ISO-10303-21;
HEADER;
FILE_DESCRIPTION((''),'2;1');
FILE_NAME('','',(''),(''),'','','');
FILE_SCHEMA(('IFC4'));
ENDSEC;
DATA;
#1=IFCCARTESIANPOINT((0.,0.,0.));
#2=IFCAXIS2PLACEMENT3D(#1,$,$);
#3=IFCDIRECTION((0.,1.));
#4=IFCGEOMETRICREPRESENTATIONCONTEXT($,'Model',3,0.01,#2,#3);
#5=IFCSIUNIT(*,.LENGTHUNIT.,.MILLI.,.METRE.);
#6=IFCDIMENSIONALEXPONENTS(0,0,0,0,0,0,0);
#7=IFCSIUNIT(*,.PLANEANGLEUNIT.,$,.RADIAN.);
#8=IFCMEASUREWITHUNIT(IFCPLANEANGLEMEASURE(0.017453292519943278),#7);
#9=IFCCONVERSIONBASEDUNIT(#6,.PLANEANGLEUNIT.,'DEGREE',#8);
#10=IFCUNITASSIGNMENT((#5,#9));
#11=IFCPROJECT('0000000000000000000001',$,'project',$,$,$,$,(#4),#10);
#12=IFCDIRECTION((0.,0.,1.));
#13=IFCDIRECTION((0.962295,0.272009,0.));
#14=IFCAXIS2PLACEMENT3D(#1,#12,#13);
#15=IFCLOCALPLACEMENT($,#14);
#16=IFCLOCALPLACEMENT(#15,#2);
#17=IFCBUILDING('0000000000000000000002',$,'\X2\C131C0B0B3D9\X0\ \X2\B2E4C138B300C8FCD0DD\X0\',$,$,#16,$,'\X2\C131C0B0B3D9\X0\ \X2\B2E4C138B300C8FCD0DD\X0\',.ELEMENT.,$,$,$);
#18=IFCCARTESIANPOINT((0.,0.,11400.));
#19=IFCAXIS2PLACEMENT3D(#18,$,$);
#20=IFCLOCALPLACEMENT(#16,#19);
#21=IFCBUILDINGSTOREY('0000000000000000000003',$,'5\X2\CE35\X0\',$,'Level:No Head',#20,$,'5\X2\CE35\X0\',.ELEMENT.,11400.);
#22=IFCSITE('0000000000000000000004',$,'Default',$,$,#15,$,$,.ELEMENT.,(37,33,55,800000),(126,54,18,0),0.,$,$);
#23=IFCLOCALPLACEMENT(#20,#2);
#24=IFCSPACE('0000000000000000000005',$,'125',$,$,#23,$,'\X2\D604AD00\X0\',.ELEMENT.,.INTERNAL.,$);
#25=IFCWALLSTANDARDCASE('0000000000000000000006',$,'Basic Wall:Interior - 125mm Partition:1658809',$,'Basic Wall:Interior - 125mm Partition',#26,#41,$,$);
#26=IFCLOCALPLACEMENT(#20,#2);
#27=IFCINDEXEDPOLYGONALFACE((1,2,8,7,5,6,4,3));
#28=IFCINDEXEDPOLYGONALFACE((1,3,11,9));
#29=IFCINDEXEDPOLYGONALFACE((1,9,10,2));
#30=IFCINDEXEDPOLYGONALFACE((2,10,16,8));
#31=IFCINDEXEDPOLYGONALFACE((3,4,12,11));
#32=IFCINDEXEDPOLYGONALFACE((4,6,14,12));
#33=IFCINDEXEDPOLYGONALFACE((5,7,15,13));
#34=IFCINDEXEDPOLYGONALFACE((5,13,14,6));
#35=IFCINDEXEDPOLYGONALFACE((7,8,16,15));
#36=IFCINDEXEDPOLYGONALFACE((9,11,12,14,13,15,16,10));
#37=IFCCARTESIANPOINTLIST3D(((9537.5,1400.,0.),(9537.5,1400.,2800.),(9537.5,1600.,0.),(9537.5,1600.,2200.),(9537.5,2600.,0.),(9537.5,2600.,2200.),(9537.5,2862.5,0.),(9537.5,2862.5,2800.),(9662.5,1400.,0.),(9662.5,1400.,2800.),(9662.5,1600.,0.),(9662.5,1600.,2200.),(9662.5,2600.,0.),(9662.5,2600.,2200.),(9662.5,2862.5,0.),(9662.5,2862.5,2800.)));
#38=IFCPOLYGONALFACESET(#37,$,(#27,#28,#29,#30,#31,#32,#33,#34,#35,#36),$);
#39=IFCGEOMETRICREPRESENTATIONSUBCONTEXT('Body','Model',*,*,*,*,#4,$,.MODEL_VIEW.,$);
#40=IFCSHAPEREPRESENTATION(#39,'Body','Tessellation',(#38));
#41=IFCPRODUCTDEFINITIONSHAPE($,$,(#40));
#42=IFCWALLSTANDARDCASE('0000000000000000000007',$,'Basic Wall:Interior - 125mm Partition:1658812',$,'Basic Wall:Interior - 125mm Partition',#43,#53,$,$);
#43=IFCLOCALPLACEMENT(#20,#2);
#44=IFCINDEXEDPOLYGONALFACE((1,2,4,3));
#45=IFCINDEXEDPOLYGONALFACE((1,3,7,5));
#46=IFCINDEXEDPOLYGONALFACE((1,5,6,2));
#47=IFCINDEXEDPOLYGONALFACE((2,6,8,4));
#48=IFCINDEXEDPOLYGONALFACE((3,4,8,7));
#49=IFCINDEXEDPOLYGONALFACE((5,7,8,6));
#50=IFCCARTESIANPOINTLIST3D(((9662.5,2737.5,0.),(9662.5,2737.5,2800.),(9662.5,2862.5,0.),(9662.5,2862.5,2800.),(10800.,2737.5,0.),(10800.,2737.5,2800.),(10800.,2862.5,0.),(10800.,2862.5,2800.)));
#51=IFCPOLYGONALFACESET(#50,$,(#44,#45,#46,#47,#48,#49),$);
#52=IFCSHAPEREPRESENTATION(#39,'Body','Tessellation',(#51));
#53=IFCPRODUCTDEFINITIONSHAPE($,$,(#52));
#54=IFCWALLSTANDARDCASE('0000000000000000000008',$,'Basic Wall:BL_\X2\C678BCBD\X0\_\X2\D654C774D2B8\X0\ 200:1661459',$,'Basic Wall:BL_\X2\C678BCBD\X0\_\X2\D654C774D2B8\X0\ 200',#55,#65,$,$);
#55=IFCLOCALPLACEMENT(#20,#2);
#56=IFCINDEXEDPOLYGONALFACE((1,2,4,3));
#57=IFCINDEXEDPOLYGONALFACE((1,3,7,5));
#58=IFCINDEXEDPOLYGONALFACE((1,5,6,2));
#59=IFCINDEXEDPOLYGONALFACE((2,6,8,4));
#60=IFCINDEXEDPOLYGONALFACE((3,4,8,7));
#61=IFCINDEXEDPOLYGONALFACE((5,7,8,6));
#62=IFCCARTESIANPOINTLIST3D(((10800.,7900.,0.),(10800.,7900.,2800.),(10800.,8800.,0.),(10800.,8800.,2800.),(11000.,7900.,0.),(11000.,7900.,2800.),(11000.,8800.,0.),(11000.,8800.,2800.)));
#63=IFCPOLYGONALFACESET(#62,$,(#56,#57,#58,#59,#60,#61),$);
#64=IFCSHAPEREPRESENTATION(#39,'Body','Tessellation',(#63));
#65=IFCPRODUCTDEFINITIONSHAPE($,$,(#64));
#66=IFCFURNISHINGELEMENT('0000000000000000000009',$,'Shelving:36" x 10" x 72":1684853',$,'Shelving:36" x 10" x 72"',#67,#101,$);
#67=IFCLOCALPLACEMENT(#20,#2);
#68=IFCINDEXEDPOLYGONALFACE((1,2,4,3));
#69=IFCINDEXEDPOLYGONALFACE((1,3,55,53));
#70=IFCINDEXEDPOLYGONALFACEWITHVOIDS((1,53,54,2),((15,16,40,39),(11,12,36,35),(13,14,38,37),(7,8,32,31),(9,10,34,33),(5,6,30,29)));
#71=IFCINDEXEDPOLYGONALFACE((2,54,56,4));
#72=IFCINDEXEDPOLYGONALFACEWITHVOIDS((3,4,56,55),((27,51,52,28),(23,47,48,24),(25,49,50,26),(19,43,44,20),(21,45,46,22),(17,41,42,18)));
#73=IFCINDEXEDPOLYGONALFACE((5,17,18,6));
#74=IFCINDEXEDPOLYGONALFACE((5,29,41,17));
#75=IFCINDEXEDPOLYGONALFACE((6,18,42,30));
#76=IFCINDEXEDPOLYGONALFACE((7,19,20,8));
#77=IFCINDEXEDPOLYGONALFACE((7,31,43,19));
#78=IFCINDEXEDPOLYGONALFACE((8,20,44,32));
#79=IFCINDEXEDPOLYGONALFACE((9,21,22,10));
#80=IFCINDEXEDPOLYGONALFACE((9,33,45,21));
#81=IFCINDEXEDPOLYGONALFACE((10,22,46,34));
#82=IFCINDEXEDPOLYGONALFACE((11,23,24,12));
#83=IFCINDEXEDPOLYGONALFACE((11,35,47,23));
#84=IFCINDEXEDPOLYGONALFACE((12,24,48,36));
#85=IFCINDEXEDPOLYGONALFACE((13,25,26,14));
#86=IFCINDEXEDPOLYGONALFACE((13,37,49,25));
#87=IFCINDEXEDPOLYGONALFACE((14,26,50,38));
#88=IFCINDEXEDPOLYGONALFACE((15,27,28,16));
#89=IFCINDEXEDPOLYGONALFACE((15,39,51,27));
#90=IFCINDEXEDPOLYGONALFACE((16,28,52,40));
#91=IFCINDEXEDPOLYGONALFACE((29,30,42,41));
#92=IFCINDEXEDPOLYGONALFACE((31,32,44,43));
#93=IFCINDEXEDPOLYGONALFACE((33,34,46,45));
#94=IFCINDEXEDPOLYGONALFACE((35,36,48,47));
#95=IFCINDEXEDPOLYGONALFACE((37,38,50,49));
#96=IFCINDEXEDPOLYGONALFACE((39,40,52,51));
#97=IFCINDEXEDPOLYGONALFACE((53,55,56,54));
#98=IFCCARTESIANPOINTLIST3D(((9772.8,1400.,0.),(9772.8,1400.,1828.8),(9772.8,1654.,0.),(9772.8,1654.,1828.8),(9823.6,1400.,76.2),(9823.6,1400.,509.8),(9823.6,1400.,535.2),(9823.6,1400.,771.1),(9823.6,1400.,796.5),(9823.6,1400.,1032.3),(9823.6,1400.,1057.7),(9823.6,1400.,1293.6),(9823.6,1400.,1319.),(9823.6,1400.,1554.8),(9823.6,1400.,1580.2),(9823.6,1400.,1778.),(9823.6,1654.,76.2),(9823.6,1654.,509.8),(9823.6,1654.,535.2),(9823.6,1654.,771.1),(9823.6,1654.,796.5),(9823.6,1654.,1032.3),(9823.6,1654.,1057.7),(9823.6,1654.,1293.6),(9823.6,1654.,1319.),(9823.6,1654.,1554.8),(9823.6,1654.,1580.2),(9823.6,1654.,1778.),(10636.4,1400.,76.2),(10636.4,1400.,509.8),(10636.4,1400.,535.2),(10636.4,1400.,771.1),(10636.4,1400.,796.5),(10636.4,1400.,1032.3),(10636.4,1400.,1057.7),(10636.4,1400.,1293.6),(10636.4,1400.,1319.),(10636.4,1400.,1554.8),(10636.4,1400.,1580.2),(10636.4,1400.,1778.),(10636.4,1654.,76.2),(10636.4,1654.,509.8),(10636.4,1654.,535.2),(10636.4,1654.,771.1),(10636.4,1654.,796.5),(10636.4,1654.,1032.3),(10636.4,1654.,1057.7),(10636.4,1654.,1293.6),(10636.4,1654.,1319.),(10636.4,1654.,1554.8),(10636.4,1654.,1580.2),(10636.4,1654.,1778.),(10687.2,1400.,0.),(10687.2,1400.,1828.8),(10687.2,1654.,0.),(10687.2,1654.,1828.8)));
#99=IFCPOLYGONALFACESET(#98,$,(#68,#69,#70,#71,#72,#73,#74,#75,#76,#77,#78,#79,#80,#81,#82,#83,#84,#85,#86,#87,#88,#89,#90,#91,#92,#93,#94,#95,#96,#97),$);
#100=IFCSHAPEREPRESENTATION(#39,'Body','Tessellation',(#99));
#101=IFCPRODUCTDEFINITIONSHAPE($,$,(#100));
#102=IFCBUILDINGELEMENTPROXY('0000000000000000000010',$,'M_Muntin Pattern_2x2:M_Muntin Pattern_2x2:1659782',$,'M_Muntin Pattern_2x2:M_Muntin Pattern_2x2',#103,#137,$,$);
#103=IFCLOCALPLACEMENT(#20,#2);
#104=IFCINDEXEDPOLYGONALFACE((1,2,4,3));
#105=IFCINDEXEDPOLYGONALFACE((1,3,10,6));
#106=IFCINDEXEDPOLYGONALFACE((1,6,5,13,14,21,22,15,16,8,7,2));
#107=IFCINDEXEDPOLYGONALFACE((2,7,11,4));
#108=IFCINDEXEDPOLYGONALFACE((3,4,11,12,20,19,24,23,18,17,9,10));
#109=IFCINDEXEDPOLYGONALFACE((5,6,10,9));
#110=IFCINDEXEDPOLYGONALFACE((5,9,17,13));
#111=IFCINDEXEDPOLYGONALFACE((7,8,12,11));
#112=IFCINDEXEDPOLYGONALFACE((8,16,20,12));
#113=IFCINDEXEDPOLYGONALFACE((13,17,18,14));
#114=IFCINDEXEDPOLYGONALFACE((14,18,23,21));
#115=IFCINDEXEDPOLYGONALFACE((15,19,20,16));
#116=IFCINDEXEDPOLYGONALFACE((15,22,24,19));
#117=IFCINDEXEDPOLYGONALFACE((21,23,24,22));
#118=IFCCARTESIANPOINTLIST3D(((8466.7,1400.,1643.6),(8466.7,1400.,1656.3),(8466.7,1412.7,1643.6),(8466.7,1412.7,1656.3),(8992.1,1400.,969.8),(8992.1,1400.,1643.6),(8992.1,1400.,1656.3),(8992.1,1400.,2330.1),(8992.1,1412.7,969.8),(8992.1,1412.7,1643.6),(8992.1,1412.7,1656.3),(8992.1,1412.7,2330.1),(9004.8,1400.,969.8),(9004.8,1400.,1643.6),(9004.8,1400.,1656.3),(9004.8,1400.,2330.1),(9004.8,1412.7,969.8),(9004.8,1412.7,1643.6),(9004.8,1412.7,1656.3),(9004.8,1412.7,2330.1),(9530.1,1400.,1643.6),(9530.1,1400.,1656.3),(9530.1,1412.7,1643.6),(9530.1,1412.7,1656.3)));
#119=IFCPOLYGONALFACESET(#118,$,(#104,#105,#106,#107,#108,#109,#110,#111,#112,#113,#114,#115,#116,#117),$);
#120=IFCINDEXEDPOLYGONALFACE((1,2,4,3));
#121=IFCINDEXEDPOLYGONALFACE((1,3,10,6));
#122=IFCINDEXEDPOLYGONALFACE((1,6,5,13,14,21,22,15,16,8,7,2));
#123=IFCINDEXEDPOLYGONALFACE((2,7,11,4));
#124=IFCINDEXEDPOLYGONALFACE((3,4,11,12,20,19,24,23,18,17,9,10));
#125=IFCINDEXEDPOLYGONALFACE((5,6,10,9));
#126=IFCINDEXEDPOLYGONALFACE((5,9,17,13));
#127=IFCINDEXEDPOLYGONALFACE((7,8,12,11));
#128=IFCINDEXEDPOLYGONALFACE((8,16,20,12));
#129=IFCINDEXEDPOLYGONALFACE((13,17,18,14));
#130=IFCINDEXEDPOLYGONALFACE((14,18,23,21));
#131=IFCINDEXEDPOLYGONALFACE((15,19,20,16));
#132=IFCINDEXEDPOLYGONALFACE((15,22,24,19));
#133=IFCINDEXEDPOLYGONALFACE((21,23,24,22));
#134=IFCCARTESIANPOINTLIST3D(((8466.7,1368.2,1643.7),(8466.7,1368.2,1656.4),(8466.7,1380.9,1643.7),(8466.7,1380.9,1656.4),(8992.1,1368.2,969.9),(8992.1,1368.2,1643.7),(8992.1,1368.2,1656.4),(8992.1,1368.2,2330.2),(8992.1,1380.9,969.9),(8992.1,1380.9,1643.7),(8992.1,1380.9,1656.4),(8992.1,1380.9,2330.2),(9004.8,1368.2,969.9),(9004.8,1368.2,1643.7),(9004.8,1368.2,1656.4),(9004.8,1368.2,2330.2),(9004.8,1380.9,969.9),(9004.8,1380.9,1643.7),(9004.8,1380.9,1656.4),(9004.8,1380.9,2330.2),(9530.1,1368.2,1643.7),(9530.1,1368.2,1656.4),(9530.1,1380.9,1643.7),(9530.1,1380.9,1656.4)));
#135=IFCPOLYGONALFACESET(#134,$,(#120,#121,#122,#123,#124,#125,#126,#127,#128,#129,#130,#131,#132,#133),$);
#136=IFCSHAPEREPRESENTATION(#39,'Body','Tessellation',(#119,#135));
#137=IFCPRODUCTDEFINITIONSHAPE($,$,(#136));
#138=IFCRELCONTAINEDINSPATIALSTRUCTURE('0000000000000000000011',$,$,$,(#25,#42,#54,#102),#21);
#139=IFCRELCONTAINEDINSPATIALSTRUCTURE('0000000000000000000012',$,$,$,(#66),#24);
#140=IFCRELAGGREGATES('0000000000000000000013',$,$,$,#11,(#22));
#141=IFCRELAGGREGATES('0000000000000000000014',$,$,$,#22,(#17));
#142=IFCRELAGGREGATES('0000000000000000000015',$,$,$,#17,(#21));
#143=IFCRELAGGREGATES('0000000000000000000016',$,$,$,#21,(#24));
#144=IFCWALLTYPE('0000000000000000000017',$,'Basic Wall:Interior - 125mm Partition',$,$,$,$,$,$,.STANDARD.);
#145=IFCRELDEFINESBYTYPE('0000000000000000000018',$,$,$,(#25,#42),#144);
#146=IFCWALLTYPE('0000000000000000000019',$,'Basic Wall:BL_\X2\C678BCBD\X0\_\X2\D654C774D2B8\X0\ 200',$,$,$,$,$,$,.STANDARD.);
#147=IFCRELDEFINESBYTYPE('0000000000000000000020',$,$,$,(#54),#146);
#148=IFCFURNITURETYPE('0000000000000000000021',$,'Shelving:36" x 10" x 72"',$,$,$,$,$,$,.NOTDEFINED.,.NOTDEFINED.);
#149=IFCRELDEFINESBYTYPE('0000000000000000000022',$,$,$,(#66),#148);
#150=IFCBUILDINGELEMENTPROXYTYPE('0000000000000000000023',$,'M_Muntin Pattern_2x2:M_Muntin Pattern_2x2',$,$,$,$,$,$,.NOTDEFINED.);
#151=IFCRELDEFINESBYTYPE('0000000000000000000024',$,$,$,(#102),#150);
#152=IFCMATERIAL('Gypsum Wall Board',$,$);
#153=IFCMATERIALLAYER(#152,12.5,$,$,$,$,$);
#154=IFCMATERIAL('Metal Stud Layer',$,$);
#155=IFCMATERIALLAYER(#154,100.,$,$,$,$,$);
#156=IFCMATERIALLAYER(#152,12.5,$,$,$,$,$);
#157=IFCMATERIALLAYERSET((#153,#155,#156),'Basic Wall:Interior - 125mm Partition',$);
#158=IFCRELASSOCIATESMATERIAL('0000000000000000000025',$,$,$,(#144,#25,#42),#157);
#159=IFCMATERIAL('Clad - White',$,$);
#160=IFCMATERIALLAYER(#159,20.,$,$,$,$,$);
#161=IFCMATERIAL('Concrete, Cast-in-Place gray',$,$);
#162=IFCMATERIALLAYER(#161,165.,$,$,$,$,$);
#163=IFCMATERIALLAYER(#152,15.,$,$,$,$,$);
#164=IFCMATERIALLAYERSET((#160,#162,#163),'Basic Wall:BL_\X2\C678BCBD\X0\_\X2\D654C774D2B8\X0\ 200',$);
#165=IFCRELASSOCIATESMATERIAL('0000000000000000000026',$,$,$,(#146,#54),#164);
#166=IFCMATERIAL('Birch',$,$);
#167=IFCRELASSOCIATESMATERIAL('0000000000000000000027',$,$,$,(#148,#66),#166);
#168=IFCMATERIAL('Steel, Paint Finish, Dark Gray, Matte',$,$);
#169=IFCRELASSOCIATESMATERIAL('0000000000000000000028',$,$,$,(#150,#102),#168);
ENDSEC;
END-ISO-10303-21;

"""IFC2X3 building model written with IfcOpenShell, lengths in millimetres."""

from ifc_helpers import new_model, entity, si_unit, converted_unit, direction, frame, frame_2d, origin, place, context, subcontext, project, spatial, polyline, rectangle, outline, extrude, source, transform, mapped, material, layer, layer_set, layer_usage, type_object, type_shapes, element, save


model = new_model("IFC2X3")

# Units and contexts
model_context = context("Model", 3, precision=0.01, world=origin(), true_north=direction((0.0, 1.0)))
body_context = subcontext(model_context, "Body", "Model", "MODEL_VIEW")
ifc_project = project(units=[si_unit("LENGTHUNIT", "METRE", prefix="MILLI"), converted_unit("PLANEANGLEUNIT", "DEGREE", entity("IfcPlaneAngleMeasure", 0.017453292519943278), si_unit("PLANEANGLEUNIT", "RADIAN"), dimensions=[0, 0, 0, 0, 0, 0, 0])], contexts=[model_context])

# Site, building, storey
site_placement = place(None, frame((0.0, 0.0, 0.0), z_axis=(0.0, 0.0, 1.0), x_axis=(0.962295, 0.272009, 0.0)))
site = spatial("IfcSite", under=ifc_project, at=site_placement, Name="Default", CompositionType="ELEMENT", RefLatitude=(37, 33, 55, 800000), RefLongitude=(126, 54, 18, 0), RefElevation=0.0)
building_placement = place(site_placement, origin())
building = spatial("IfcBuilding", under=site, at=building_placement, Name="성산동 다세대주택", LongName="성산동 다세대주택", CompositionType="ELEMENT")
storey_placement = place(building_placement, frame((0.0, 0.0, 11400.0)))
storey = spatial("IfcBuildingStorey", under=building, at=storey_placement, Name="5층", ObjectType="Level:No Head", LongName="5층", CompositionType="ELEMENT", Elevation=11400.0)

# Shared definitions
ifc_material_1 = material(Name="Steel, Paint Finish, Dark Gray, Matte")
ifc_material_2 = material(Name="Concrete, Cast-in-Place gray")
ifc_material_3 = material(Name="Gypsum Wall Board")

# Wall, opening
ifc_layer_1 = layer(ifc_material_3, 12.5)
ifc_material_4 = material(Name="Metal Stud Layer")
ifc_layer_2 = layer(ifc_material_4, 100.0)
ifc_layer_3 = layer(ifc_material_3, 12.5)
ifc_layer_set_1 = layer_set([ifc_layer_1, ifc_layer_2, ifc_layer_3], Name="Basic Wall:Interior - 125mm Partition")
ifc_layer_usage_1 = layer_usage(ifc_layer_set_1, "AXIS2", "NEGATIVE", 62.5)
wall_type_1 = type_object("IfcWallType", Name="Basic Wall:Interior - 125mm Partition", PredefinedType="STANDARD", material=ifc_layer_set_1)
wall_1_placement = place(storey_placement, frame((9600.0, 1400.0, 0.0), z_axis=(0.0, 0.0, 1.0), x_axis=(0.0, 1.0, 0.0)))
wall_1 = element("IfcWallStandardCase", 1, at=wall_1_placement, inside=storey, type_object=wall_type_1, material=ifc_layer_usage_1, Name="Basic Wall:Interior - 125mm Partition:1658809", ObjectType="Basic Wall:Interior - 125mm Partition", context=body_context, shape_type="SweptSolid", body=[
    extrude(rectangle(XDim=1462.5, YDim=125.0, at=frame_2d((731.2, 0.0), x_axis=(-1.0, 0.0))), origin(), (0.0, 0.0, 1.0), 2800.0),
])
opening_1_placement = place(wall_1_placement, frame((200.0, -62.5, 0.0)))
element("IfcOpeningElement", 2, at=opening_1_placement, cuts=wall_1, ObjectType="Opening", context=body_context, shape_type="SweptSolid", body=[
    extrude(rectangle(XDim=2200.0, YDim=1000.0, at=frame_2d((1100.0, 500.0), x_axis=(1.0, 0.0))), frame((0.0, 0.0, 0.0), z_axis=(0.0, 1.0, 0.0), x_axis=(0.0, 0.0, 1.0)), (0.0, 0.0, 1.0), 125.0),
])

# Walls
ifc_layer_usage_2 = layer_usage(ifc_layer_set_1, "AXIS2", "NEGATIVE", 62.5)
wall_2_placement = place(storey_placement, frame((9662.5, 2800.0, 0.0)))
element("IfcWallStandardCase", 3, at=wall_2_placement, inside=storey, type_object=wall_type_1, material=ifc_layer_usage_2, Name="Basic Wall:Interior - 125mm Partition:1658812", ObjectType="Basic Wall:Interior - 125mm Partition", context=body_context, shape_type="SweptSolid", body=[
    extrude(rectangle(XDim=1137.5, YDim=125.0, at=frame_2d((568.7, 0.0), x_axis=(-1.0, 0.0))), origin(), (0.0, 0.0, 1.0), 2800.0),
])
ifc_material_5 = material(Name="Clad - White")
ifc_layer_4 = layer(ifc_material_5, 20.0)
ifc_layer_5 = layer(ifc_material_2, 165.0)
ifc_layer_6 = layer(ifc_material_3, 15.0)
ifc_layer_set_2 = layer_set([ifc_layer_4, ifc_layer_5, ifc_layer_6], Name="Basic Wall:BL_외벽_화이트 200")
ifc_layer_usage_3 = layer_usage(ifc_layer_set_2, "AXIS2", "NEGATIVE", 100.0)
wall_type_2 = type_object("IfcWallType", Name="Basic Wall:BL_외벽_화이트 200", PredefinedType="STANDARD", material=ifc_layer_set_2)
wall_3_placement = place(storey_placement, frame((10900.0, 8800.0, 0.0), z_axis=(0.0, 0.0, 1.0), x_axis=(0.0, -1.0, 0.0)))
element("IfcWallStandardCase", 4, at=wall_3_placement, inside=storey, type_object=wall_type_2, material=ifc_layer_usage_3, Name="Basic Wall:BL_외벽_화이트 200:1661459", ObjectType="Basic Wall:BL_외벽_화이트 200", context=body_context, shape_type="SweptSolid", body=[
    extrude(rectangle(XDim=900.0, YDim=200.0, at=frame_2d((450.0, 0.0), x_axis=(-1.0, 0.0))), origin(), (0.0, 0.0, 1.0), 2800.0),
])

# Shared definitions
space_1_placement = place(storey_placement, origin())
space_1 = spatial("IfcSpace", under=storey, at=space_1_placement, Name="125", LongName="현관", CompositionType="ELEMENT", InteriorOrExteriorSpace="INTERNAL")

# Furnishing element
ifc_material_6 = material(Name="Birch")
furniture_type_1 = type_object("IfcFurnitureType", Name="Shelving:36\" x 10\" x 72\"", AssemblyPlace="NOTDEFINED", material=ifc_material_6)
shared_shape_1 = source(origin(), body_context, "Body", "SweptSolid", [
    extrude(outline(polyline([(-457.2, -914.4), (457.2, -914.4), (457.2, 914.4), (-457.2, 914.4), (-457.2, -914.4)]), holes=[polyline([(-406.4, 863.6), (406.4, 863.6), (406.4, 665.8), (-406.4, 665.8), (-406.4, 863.6)]), polyline([(-406.4, -838.2), (-406.4, -404.6), (406.4, -404.6), (406.4, -838.2), (-406.4, -838.2)]), polyline([(406.4, 143.3), (-406.4, 143.3), (-406.4, 379.2), (406.4, 379.2), (406.4, 143.3)]), polyline([(-406.4, 640.4), (406.4, 640.4), (406.4, 404.6), (-406.4, 404.6), (-406.4, 640.4)]), polyline([(-406.4, 117.9), (406.4, 117.9), (406.4, -117.9), (-406.4, -117.9), (-406.4, 117.9)]), polyline([(-406.4, -143.3), (406.4, -143.3), (406.4, -379.2), (-406.4, -379.2), (-406.4, -143.3)])]), frame((0.0, -431.8, 914.4), z_axis=(0.0, 1.0, 0.0), x_axis=(-1.0, 0.0, 0.0)), (0.0, 0.0, 1.0), 254.0),
])
type_shapes(furniture_type_1, [shared_shape_1])
furnishing_1_placement = place(space_1_placement, frame((10230.0, 1222.2, 0.0), z_axis=(0.0, 0.0, 1.0), x_axis=(-1.0, 0.0, 0.0)))
element("IfcFurnishingElement", 5, at=furnishing_1_placement, inside=space_1, type_object=furniture_type_1, material=ifc_material_6, Name="Shelving:36\" x 10\" x 72\":1684853", ObjectType="Shelving:36\" x 10\" x 72\"", context=body_context, shape_type="MappedRepresentation", body=[
    mapped(shared_shape_1, transform((0.0, 0.0, 0.0), scale=1.0)),
])

# Building element proxy
building_element_proxy_type_1 = type_object("IfcBuildingElementProxyType", Name="M_Muntin Pattern_2x2:M_Muntin Pattern_2x2", PredefinedType="NOTDEFINED", material=ifc_material_1)
shared_shape_2 = source(origin(), body_context, "Body", "SweptSolid", [
    extrude(outline(polyline([(6.4, -6.4), (680.1, -6.4), (680.1, 6.3), (6.4, 6.3), (6.4, 531.7), (-6.3, 531.7), (-6.3, 6.3), (-680.2, 6.3), (-680.2, -6.4), (-6.3, -6.4), (-6.3, -531.7), (6.4, -531.7), (6.4, -6.4)])), frame((0.0, -22.2, 680.1), z_axis=(0.0, 1.0, 0.0), x_axis=(0.0, 0.0, 1.0)), (0.0, 0.0, 1.0), 12.7),
    extrude(outline(polyline([(6.4, -6.4), (680.2, -6.4), (680.2, 6.3), (6.4, 6.3), (6.4, 531.7), (-6.3, 531.7), (-6.3, 6.3), (-680.2, 6.3), (-680.2, -6.4), (-6.3, -6.4), (-6.3, -531.7), (6.4, -531.7), (6.4, -6.4)])), frame((0.0, 9.5, 680.2), z_axis=(0.0, 1.0, 0.0), x_axis=(0.0, 0.0, 1.0)), (0.0, 0.0, 1.0), 12.7),
])
type_shapes(building_element_proxy_type_1, [shared_shape_2])
proxy_1_placement = place(storey_placement, frame((8998.4, 1390.5, 969.9), z_axis=(0.0, 0.0, 1.0), x_axis=(-1.0, 0.0, 0.0)))
element("IfcBuildingElementProxy", 6, at=proxy_1_placement, inside=storey, type_object=building_element_proxy_type_1, material=ifc_material_1, Name="M_Muntin Pattern_2x2:M_Muntin Pattern_2x2:1659782", ObjectType="M_Muntin Pattern_2x2:M_Muntin Pattern_2x2", context=body_context, shape_type="MappedRepresentation", body=[
    mapped(shared_shape_2, transform((0.0, 0.0, 0.0), scale=1.0)),
])

save(model, "model.ifc")
